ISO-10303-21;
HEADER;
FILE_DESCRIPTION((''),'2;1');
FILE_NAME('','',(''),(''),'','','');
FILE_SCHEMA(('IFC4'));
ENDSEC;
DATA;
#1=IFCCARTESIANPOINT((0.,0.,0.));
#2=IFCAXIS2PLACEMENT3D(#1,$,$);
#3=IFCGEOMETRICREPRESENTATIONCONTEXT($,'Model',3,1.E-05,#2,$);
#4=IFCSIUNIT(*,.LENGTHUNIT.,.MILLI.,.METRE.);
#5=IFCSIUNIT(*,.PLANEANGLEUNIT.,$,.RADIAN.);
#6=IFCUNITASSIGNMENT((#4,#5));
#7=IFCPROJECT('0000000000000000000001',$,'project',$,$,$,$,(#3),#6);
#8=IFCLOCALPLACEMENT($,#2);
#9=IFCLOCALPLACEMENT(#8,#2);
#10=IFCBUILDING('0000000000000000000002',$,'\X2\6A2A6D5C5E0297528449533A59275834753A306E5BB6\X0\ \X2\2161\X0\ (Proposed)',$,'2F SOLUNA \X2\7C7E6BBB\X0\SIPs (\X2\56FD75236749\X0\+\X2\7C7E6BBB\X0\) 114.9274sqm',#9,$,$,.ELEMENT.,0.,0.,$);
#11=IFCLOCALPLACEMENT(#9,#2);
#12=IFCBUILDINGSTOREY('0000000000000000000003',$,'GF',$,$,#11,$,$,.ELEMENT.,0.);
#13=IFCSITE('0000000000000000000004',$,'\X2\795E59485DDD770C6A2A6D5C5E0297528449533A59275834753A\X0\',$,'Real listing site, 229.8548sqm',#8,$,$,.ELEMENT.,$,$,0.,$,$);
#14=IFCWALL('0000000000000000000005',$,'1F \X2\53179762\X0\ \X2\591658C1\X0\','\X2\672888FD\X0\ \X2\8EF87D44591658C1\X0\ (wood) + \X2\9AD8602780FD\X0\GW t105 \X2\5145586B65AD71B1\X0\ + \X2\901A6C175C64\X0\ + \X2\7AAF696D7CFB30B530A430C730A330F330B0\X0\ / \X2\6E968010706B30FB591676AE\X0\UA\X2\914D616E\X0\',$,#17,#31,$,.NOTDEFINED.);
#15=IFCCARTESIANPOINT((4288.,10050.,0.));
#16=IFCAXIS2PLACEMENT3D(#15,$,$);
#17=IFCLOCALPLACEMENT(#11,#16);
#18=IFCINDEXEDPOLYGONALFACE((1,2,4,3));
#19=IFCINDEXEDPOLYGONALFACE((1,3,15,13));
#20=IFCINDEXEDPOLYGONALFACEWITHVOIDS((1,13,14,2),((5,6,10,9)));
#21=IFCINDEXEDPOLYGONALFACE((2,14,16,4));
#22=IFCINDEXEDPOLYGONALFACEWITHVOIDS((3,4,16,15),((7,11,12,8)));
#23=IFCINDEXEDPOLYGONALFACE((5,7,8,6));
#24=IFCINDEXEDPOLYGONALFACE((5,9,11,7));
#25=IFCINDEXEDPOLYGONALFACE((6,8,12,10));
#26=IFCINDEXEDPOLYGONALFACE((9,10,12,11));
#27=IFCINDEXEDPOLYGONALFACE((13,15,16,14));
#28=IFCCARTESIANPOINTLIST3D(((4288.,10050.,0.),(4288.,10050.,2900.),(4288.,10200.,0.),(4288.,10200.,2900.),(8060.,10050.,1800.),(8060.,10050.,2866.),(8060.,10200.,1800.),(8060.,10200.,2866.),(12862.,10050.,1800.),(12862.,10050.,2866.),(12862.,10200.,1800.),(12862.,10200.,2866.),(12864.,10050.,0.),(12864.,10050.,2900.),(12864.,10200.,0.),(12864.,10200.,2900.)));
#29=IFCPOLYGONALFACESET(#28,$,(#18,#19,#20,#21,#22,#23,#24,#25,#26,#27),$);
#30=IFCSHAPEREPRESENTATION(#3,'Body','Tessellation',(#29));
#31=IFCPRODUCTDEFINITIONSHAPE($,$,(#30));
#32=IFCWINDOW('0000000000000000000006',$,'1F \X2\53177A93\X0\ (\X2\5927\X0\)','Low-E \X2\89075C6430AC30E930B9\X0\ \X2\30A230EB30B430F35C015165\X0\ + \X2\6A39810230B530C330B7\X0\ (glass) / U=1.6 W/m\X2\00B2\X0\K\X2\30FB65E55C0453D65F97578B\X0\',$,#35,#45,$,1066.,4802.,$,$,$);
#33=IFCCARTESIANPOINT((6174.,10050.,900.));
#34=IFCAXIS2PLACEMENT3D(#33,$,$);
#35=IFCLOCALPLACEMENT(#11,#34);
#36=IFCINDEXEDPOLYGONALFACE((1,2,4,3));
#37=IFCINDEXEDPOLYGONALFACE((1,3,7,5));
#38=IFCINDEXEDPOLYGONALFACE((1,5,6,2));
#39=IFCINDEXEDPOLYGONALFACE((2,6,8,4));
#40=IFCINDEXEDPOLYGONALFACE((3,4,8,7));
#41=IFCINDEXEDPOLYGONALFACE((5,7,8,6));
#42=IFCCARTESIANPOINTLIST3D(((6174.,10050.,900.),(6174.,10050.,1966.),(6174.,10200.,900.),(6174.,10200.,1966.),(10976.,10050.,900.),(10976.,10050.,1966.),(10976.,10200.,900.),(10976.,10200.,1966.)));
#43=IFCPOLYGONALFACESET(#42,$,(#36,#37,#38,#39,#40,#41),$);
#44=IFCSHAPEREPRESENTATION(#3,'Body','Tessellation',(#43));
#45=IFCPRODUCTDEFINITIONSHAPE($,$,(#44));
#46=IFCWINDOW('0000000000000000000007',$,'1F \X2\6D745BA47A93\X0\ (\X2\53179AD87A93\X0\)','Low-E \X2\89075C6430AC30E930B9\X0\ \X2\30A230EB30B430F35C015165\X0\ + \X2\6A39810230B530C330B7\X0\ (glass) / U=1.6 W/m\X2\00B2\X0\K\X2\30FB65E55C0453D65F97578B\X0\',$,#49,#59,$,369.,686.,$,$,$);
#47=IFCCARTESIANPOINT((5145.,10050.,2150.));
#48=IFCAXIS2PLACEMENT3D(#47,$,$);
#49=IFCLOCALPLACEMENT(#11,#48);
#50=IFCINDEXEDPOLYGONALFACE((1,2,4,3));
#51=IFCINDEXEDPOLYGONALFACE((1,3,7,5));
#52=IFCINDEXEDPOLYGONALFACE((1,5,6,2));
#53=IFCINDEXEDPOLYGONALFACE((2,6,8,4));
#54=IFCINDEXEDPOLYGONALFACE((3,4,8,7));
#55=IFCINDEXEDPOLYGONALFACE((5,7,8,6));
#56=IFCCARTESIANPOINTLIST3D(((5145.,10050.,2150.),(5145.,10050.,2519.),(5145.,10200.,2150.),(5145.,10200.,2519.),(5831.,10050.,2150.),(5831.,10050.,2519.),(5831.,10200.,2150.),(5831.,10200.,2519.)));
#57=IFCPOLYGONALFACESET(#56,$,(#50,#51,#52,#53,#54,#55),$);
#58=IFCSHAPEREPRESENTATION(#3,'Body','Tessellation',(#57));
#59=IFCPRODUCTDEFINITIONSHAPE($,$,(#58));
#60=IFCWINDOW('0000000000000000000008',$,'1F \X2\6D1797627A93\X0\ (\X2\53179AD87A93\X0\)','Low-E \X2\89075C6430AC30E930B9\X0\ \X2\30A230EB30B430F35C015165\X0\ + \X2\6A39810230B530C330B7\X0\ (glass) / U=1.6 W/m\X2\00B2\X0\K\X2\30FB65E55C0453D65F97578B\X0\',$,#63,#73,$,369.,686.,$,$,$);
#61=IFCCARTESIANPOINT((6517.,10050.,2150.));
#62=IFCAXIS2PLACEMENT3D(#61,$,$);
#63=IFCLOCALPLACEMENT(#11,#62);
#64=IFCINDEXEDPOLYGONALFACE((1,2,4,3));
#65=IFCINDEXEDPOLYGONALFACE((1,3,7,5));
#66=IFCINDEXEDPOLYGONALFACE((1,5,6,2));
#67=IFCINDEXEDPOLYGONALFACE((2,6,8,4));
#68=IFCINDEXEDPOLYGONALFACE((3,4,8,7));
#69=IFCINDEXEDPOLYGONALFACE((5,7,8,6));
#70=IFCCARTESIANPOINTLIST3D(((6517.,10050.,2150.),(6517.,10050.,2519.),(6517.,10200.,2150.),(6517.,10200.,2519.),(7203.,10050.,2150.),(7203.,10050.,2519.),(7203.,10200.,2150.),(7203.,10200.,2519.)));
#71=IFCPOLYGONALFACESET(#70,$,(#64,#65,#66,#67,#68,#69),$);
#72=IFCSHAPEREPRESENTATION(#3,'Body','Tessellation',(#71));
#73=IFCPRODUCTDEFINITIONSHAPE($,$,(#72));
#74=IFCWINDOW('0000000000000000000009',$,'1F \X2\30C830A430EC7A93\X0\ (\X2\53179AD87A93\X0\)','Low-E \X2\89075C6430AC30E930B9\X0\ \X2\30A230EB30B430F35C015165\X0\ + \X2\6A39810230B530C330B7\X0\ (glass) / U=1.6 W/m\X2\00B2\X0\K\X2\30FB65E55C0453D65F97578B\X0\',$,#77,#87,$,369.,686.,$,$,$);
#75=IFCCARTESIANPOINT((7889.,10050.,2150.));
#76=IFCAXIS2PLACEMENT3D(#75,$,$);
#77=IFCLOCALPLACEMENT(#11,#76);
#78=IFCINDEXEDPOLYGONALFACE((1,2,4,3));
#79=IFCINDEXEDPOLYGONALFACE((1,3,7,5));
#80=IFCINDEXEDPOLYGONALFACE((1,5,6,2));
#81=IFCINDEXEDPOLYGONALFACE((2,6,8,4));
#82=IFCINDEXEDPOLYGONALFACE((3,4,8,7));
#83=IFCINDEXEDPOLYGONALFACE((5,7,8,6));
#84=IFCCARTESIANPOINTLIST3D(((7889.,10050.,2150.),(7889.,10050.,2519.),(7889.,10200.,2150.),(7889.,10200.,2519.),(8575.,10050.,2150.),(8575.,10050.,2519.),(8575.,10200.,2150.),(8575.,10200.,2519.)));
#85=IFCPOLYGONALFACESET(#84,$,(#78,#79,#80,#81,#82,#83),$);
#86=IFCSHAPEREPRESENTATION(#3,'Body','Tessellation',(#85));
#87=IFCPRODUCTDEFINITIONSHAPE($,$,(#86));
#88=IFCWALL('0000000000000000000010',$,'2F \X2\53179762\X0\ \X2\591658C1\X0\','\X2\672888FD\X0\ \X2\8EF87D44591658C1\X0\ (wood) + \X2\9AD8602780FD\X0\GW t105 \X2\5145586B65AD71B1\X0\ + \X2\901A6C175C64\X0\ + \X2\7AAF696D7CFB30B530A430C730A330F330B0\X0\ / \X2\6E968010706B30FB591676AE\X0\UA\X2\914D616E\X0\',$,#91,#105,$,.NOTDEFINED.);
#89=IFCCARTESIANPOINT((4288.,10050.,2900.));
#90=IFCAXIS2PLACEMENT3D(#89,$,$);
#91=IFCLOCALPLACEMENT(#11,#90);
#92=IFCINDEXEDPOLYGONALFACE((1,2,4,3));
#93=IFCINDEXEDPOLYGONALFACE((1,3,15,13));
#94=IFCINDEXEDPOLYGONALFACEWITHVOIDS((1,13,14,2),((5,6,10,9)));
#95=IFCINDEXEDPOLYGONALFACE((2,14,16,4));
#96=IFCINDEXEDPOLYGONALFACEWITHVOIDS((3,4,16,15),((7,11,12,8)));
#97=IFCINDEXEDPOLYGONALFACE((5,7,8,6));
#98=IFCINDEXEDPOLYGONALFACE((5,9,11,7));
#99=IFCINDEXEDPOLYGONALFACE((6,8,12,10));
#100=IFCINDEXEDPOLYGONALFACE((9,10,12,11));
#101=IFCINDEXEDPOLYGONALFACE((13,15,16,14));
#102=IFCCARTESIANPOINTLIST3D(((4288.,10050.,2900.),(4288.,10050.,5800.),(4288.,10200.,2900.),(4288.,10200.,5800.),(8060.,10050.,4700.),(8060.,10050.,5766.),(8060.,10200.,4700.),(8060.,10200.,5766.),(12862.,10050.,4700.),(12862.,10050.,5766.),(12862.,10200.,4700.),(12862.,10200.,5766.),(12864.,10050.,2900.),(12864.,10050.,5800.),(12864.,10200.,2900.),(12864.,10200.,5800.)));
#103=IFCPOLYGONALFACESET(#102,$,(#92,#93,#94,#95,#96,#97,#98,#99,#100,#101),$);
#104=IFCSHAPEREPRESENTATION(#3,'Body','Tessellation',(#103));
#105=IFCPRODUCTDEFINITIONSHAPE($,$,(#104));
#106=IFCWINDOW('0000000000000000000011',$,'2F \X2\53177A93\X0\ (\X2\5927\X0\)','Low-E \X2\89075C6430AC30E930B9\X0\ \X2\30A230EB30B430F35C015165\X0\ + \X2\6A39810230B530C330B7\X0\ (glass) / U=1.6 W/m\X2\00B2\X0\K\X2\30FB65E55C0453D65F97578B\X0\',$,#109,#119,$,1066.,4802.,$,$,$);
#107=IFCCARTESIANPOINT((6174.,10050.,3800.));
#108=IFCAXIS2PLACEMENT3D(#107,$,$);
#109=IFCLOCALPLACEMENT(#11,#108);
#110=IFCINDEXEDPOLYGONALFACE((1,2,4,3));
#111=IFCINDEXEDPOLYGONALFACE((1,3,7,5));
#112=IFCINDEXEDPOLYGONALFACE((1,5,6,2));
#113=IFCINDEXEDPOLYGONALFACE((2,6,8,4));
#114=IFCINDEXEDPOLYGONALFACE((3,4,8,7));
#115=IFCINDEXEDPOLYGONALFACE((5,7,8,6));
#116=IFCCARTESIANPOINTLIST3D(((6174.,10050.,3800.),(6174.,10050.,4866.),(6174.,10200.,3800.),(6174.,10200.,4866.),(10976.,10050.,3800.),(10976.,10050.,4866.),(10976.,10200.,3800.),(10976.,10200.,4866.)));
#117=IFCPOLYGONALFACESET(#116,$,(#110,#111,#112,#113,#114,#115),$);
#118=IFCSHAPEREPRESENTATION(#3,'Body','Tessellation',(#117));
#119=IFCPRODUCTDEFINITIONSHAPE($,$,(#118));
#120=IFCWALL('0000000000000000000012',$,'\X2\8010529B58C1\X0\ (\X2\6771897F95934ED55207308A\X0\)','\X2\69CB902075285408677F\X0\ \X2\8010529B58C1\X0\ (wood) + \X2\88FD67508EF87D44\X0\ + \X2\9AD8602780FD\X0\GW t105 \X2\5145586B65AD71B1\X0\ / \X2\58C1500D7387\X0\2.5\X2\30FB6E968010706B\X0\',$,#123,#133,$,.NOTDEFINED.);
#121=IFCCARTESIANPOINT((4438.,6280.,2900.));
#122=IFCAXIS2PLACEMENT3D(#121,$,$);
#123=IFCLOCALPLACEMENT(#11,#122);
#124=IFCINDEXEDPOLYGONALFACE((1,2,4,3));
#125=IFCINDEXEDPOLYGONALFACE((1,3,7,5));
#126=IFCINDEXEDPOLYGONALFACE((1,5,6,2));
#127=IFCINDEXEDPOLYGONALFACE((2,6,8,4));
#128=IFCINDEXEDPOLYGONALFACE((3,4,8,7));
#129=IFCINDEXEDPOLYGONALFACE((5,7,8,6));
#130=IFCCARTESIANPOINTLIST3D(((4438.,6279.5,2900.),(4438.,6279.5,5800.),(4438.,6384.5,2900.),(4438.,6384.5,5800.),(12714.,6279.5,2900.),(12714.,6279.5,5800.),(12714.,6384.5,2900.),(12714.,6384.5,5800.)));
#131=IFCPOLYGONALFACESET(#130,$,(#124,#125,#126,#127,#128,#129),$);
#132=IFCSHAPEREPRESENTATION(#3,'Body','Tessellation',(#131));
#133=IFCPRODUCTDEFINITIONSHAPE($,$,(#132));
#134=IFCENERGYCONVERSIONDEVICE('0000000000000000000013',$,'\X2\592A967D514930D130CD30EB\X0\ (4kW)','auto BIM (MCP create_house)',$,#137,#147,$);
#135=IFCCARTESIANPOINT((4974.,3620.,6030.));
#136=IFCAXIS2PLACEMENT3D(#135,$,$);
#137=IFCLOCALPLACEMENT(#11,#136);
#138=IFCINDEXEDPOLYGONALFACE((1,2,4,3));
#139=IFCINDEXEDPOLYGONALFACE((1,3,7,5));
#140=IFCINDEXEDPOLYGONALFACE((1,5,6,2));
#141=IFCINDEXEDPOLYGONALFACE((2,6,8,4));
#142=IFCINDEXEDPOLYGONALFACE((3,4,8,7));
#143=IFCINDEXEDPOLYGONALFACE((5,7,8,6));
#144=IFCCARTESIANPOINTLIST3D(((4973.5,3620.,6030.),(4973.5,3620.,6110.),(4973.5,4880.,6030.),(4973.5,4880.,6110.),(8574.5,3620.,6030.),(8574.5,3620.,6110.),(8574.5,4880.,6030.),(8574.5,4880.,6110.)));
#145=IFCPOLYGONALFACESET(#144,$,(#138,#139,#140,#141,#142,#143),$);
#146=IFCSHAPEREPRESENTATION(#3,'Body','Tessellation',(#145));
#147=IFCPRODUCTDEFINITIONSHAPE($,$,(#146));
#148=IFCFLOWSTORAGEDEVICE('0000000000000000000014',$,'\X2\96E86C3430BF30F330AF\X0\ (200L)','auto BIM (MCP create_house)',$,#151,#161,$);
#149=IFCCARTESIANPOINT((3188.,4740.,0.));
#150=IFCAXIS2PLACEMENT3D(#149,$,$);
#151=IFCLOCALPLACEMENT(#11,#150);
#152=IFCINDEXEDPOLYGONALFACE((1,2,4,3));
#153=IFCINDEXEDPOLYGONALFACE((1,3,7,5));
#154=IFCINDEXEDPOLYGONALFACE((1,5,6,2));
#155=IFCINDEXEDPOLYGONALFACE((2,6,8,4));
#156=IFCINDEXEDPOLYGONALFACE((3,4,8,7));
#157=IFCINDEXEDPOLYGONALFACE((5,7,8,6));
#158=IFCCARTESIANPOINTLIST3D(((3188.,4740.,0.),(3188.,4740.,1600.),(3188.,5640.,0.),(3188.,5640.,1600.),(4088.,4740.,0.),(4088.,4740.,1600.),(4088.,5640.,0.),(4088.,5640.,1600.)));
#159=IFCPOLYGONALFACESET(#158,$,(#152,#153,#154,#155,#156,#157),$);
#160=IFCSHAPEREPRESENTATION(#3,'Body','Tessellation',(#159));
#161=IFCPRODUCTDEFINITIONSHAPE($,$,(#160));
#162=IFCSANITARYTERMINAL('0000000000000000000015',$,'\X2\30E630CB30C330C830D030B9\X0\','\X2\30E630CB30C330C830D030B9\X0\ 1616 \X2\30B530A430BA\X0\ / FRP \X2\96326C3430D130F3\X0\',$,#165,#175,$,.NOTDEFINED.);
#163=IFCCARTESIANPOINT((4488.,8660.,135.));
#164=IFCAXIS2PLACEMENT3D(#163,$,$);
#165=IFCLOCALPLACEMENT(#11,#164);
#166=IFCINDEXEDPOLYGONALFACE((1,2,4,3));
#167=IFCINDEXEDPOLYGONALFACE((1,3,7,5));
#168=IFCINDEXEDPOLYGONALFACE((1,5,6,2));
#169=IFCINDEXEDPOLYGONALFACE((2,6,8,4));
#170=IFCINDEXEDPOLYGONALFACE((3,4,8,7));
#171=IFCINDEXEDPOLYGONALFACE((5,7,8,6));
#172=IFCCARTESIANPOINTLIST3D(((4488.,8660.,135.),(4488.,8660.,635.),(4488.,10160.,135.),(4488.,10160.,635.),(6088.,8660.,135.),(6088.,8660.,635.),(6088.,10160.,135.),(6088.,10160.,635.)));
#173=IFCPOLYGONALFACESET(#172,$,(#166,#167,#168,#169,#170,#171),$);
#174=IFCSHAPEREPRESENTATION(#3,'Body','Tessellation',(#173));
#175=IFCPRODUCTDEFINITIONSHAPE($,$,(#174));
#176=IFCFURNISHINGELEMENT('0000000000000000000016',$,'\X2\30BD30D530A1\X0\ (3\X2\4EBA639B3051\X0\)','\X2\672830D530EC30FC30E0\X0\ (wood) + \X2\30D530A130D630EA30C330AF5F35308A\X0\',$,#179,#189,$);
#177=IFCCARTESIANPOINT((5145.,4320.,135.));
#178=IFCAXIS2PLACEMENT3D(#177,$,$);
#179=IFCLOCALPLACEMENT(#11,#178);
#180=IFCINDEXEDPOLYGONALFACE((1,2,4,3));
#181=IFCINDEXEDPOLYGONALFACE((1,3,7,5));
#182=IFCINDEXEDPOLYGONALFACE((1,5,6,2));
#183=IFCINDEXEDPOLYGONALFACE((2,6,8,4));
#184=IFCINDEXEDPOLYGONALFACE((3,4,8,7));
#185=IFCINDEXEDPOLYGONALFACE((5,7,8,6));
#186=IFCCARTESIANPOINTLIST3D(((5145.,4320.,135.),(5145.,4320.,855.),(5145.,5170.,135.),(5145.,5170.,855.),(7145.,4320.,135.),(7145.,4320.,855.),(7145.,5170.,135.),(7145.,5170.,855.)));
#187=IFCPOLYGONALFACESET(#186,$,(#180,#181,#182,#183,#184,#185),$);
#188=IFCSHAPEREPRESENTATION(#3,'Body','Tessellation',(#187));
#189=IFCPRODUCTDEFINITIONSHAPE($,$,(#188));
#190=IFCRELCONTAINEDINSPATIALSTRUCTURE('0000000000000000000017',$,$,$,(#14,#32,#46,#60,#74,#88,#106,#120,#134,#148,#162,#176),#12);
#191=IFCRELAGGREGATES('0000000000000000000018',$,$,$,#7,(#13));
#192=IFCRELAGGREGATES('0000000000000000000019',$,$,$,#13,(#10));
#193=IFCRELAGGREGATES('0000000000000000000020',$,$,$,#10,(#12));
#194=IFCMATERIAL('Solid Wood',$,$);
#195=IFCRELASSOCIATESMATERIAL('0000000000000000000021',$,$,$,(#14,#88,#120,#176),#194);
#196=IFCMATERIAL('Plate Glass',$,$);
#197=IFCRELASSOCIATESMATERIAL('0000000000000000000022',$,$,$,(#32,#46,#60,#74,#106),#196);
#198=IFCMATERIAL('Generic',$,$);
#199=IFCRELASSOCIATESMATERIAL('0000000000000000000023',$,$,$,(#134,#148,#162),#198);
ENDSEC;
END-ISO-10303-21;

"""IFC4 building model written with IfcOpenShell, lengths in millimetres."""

from ifc_helpers import new_model, si_unit, frame, frame_2d, origin, place, context, project, spatial, rectangle, extrude, material, element, fill, save


model = new_model("IFC4")

# Units and contexts
model_context = context("Model", 3, precision=1e-05, world=origin())
ifc_project = project(units=[si_unit("LENGTHUNIT", "METRE", prefix="MILLI"), si_unit("PLANEANGLEUNIT", "RADIAN")], contexts=[model_context])

# Site, building, storey
site_placement = place(None, origin())
site = spatial("IfcSite", under=ifc_project, at=site_placement, Name="神奈川県横浜市青葉区大場町", ObjectType="Real listing site, 229.8548sqm", CompositionType="ELEMENT", RefElevation=0.0)
building_placement = place(site_placement, origin())
building = spatial("IfcBuilding", under=site, at=building_placement, Name="横浜市青葉区大場町の家 Ⅱ (Proposed)", ObjectType="2F SOLUNA 籾殻SIPs (国産杉+籾殻) 114.9274sqm", CompositionType="ELEMENT", ElevationOfRefHeight=0.0, ElevationOfTerrain=0.0)
storey_placement = place(building_placement, origin())
storey = spatial("IfcBuildingStorey", under=building, at=storey_placement, Name="GF", CompositionType="ELEMENT", Elevation=0.0)

# Wall, openings, windows
ifc_material_1 = material(Name="Solid Wood")
wall_1_placement = place(storey_placement, frame((4288.0, 10050.0, 0.0)))
wall_1 = element("IfcWall", 1, at=wall_1_placement, inside=storey, material=ifc_material_1, Name="1F 北面 外壁", Description="木製 軸組外壁 (wood) + 高性能GW t105 充填断熱 + 通気層 + 窯業系サイディング / 準耐火・外皮UA配慮", PredefinedType="NOTDEFINED", context=model_context, shape_type="SweptSolid", body=[
    extrude(rectangle(XDim=8576.0, YDim=150.0, at=frame_2d((4288.0, 75.0))), frame((4288.0, 10050.0, 0.0)), (0.0, 0.0, 1.0), 2900.0),
])
opening_1_placement = place(storey_placement, frame((6174.0, 10050.0, 900.0)))
opening_1 = element("IfcOpeningElement", 2, at=opening_1_placement, cuts=wall_1, PredefinedType="NOTDEFINED", context=model_context, shape_type="SweptSolid", body=[
    extrude(rectangle(XDim=4802.0, YDim=150.0, at=frame_2d((2401.0, 75.0))), frame((6174.0, 10050.0, 900.0)), (0.0, 0.0, 1.0), 1066.0),
])
opening_2_placement = place(storey_placement, frame((5145.0, 10050.0, 2150.0)))
opening_2 = element("IfcOpeningElement", 3, at=opening_2_placement, cuts=wall_1, PredefinedType="NOTDEFINED", context=model_context, shape_type="SweptSolid", body=[
    extrude(rectangle(XDim=686.0, YDim=150.0, at=frame_2d((343.0, 75.0))), frame((5145.0, 10050.0, 2150.0)), (0.0, 0.0, 1.0), 369.0),
])
opening_3_placement = place(storey_placement, frame((6517.0, 10050.0, 2150.0)))
opening_3 = element("IfcOpeningElement", 4, at=opening_3_placement, cuts=wall_1, PredefinedType="NOTDEFINED", context=model_context, shape_type="SweptSolid", body=[
    extrude(rectangle(XDim=686.0, YDim=150.0, at=frame_2d((343.0, 75.0))), frame((6517.0, 10050.0, 2150.0)), (0.0, 0.0, 1.0), 369.0),
])
opening_4_placement = place(storey_placement, frame((7889.0, 10050.0, 2150.0)))
opening_4 = element("IfcOpeningElement", 5, at=opening_4_placement, cuts=wall_1, PredefinedType="NOTDEFINED", context=model_context, shape_type="SweptSolid", body=[
    extrude(rectangle(XDim=686.0, YDim=150.0, at=frame_2d((343.0, 75.0))), frame((7889.0, 10050.0, 2150.0)), (0.0, 0.0, 1.0), 369.0),
])
ifc_material_2 = material(Name="Plate Glass")
window_1_placement = place(storey_placement, frame((6174.0, 10050.0, 900.0)))
window_1 = element("IfcWindow", 6, at=window_1_placement, inside=storey, material=ifc_material_2, Name="1F 北窓 (大)", Description="Low-E 複層ガラス アルゴン封入 + 樹脂サッシ (glass) / U=1.6 W/m²K・日射取得型", OverallHeight=1066.0, OverallWidth=4802.0, context=model_context, shape_type="SweptSolid", body=[
    extrude(rectangle(XDim=4802.0, YDim=150.0, at=frame_2d((2401.0, 75.0))), frame((6174.0, 10050.0, 900.0)), (0.0, 0.0, 1.0), 1066.0),
])
fill(opening_1, window_1)
window_2_placement = place(storey_placement, frame((5145.0, 10050.0, 2150.0)))
window_2 = element("IfcWindow", 7, at=window_2_placement, inside=storey, material=ifc_material_2, Name="1F 浴室窓 (北高窓)", Description="Low-E 複層ガラス アルゴン封入 + 樹脂サッシ (glass) / U=1.6 W/m²K・日射取得型", OverallHeight=369.0, OverallWidth=686.0, context=model_context, shape_type="SweptSolid", body=[
    extrude(rectangle(XDim=686.0, YDim=150.0, at=frame_2d((343.0, 75.0))), frame((5145.0, 10050.0, 2150.0)), (0.0, 0.0, 1.0), 369.0),
])
fill(opening_2, window_2)
window_3_placement = place(storey_placement, frame((6517.0, 10050.0, 2150.0)))
window_3 = element("IfcWindow", 8, at=window_3_placement, inside=storey, material=ifc_material_2, Name="1F 洗面窓 (北高窓)", Description="Low-E 複層ガラス アルゴン封入 + 樹脂サッシ (glass) / U=1.6 W/m²K・日射取得型", OverallHeight=369.0, OverallWidth=686.0, context=model_context, shape_type="SweptSolid", body=[
    extrude(rectangle(XDim=686.0, YDim=150.0, at=frame_2d((343.0, 75.0))), frame((6517.0, 10050.0, 2150.0)), (0.0, 0.0, 1.0), 369.0),
])
fill(opening_3, window_3)
window_4_placement = place(storey_placement, frame((7889.0, 10050.0, 2150.0)))
window_4 = element("IfcWindow", 9, at=window_4_placement, inside=storey, material=ifc_material_2, Name="1F トイレ窓 (北高窓)", Description="Low-E 複層ガラス アルゴン封入 + 樹脂サッシ (glass) / U=1.6 W/m²K・日射取得型", OverallHeight=369.0, OverallWidth=686.0, context=model_context, shape_type="SweptSolid", body=[
    extrude(rectangle(XDim=686.0, YDim=150.0, at=frame_2d((343.0, 75.0))), frame((7889.0, 10050.0, 2150.0)), (0.0, 0.0, 1.0), 369.0),
])
fill(opening_4, window_4)

# Wall, opening, window
wall_2_placement = place(storey_placement, frame((4288.0, 10050.0, 2900.0)))
wall_2 = element("IfcWall", 10, at=wall_2_placement, inside=storey, material=ifc_material_1, Name="2F 北面 外壁", Description="木製 軸組外壁 (wood) + 高性能GW t105 充填断熱 + 通気層 + 窯業系サイディング / 準耐火・外皮UA配慮", PredefinedType="NOTDEFINED", context=model_context, shape_type="SweptSolid", body=[
    extrude(rectangle(XDim=8576.0, YDim=150.0, at=frame_2d((4288.0, 75.0))), frame((4288.0, 10050.0, 2900.0)), (0.0, 0.0, 1.0), 2900.0),
])
opening_5_placement = place(storey_placement, frame((6174.0, 10050.0, 3800.0)))
opening_5 = element("IfcOpeningElement", 11, at=opening_5_placement, cuts=wall_2, PredefinedType="NOTDEFINED", context=model_context, shape_type="SweptSolid", body=[
    extrude(rectangle(XDim=4802.0, YDim=150.0, at=frame_2d((2401.0, 75.0))), frame((6174.0, 10050.0, 3800.0)), (0.0, 0.0, 1.0), 1066.0),
])
window_5_placement = place(storey_placement, frame((6174.0, 10050.0, 3800.0)))
window_5 = element("IfcWindow", 12, at=window_5_placement, inside=storey, material=ifc_material_2, Name="2F 北窓 (大)", Description="Low-E 複層ガラス アルゴン封入 + 樹脂サッシ (glass) / U=1.6 W/m²K・日射取得型", OverallHeight=1066.0, OverallWidth=4802.0, context=model_context, shape_type="SweptSolid", body=[
    extrude(rectangle(XDim=4802.0, YDim=150.0, at=frame_2d((2401.0, 75.0))), frame((6174.0, 10050.0, 3800.0)), (0.0, 0.0, 1.0), 1066.0),
])
fill(opening_5, window_5)

# Wall
wall_3_placement = place(storey_placement, frame((4438.0, 6280.0, 2900.0)))
element("IfcWall", 13, at=wall_3_placement, inside=storey, material=ifc_material_1, Name="耐力壁 (東西間仕切り)", Description="構造用合板 耐力壁 (wood) + 製材軸組 + 高性能GW t105 充填断熱 / 壁倍率2.5・準耐火", PredefinedType="NOTDEFINED", context=model_context, shape_type="SweptSolid", body=[
    extrude(rectangle(XDim=8276.0, YDim=105.0, at=frame_2d((4138.0, 52.0))), frame((4438.0, 6280.0, 2900.0)), (0.0, 0.0, 1.0), 2900.0),
])

# Energy conversion device
ifc_material_3 = material(Name="Generic")
energy_conversion_device_placement = place(storey_placement, frame((4974.0, 3620.0, 6030.0)))
element("IfcEnergyConversionDevice", 14, at=energy_conversion_device_placement, inside=storey, material=ifc_material_3, Name="太陽光パネル (4kW)", Description="auto BIM (MCP create_house)", context=model_context, shape_type="SweptSolid", body=[
    extrude(rectangle(XDim=3601.0, YDim=1260.0, at=frame_2d((1800.0, 630.0))), frame((4974.0, 3620.0, 6030.0)), (0.0, 0.0, 1.0), 80.0),
])

# Flow storage device
flow_storage_device_placement = place(storey_placement, frame((3188.0, 4740.0, 0.0)))
element("IfcFlowStorageDevice", 15, at=flow_storage_device_placement, inside=storey, material=ifc_material_3, Name="雨水タンク (200L)", Description="auto BIM (MCP create_house)", context=model_context, shape_type="SweptSolid", body=[
    extrude(rectangle(XDim=900.0, YDim=900.0, at=frame_2d((450.0, 450.0))), frame((3188.0, 4740.0, 0.0)), (0.0, 0.0, 1.0), 1600.0),
])

# Sanitary terminal
sanitary_terminal_placement = place(storey_placement, frame((4488.0, 8660.0, 135.0)))
element("IfcSanitaryTerminal", 16, at=sanitary_terminal_placement, inside=storey, material=ifc_material_3, Name="ユニットバス", Description="ユニットバス 1616 サイズ / FRP 防水パン", PredefinedType="NOTDEFINED", context=model_context, shape_type="SweptSolid", body=[
    extrude(rectangle(XDim=1600.0, YDim=1500.0, at=frame_2d((800.0, 750.0))), frame((4488.0, 8660.0, 135.0)), (0.0, 0.0, 1.0), 500.0),
])

# Furnishing element
furnishing_1_placement = place(storey_placement, frame((5145.0, 4320.0, 135.0)))
element("IfcFurnishingElement", 17, at=furnishing_1_placement, inside=storey, material=ifc_material_1, Name="ソファ (3人掛け)", Description="木フレーム (wood) + ファブリック張り", context=model_context, shape_type="SweptSolid", body=[
    extrude(rectangle(XDim=2000.0, YDim=850.0, at=frame_2d((1000.0, 425.0))), frame((5145.0, 4320.0, 135.0)), (0.0, 0.0, 1.0), 720.0),
])

save(model, "model.ifc")
